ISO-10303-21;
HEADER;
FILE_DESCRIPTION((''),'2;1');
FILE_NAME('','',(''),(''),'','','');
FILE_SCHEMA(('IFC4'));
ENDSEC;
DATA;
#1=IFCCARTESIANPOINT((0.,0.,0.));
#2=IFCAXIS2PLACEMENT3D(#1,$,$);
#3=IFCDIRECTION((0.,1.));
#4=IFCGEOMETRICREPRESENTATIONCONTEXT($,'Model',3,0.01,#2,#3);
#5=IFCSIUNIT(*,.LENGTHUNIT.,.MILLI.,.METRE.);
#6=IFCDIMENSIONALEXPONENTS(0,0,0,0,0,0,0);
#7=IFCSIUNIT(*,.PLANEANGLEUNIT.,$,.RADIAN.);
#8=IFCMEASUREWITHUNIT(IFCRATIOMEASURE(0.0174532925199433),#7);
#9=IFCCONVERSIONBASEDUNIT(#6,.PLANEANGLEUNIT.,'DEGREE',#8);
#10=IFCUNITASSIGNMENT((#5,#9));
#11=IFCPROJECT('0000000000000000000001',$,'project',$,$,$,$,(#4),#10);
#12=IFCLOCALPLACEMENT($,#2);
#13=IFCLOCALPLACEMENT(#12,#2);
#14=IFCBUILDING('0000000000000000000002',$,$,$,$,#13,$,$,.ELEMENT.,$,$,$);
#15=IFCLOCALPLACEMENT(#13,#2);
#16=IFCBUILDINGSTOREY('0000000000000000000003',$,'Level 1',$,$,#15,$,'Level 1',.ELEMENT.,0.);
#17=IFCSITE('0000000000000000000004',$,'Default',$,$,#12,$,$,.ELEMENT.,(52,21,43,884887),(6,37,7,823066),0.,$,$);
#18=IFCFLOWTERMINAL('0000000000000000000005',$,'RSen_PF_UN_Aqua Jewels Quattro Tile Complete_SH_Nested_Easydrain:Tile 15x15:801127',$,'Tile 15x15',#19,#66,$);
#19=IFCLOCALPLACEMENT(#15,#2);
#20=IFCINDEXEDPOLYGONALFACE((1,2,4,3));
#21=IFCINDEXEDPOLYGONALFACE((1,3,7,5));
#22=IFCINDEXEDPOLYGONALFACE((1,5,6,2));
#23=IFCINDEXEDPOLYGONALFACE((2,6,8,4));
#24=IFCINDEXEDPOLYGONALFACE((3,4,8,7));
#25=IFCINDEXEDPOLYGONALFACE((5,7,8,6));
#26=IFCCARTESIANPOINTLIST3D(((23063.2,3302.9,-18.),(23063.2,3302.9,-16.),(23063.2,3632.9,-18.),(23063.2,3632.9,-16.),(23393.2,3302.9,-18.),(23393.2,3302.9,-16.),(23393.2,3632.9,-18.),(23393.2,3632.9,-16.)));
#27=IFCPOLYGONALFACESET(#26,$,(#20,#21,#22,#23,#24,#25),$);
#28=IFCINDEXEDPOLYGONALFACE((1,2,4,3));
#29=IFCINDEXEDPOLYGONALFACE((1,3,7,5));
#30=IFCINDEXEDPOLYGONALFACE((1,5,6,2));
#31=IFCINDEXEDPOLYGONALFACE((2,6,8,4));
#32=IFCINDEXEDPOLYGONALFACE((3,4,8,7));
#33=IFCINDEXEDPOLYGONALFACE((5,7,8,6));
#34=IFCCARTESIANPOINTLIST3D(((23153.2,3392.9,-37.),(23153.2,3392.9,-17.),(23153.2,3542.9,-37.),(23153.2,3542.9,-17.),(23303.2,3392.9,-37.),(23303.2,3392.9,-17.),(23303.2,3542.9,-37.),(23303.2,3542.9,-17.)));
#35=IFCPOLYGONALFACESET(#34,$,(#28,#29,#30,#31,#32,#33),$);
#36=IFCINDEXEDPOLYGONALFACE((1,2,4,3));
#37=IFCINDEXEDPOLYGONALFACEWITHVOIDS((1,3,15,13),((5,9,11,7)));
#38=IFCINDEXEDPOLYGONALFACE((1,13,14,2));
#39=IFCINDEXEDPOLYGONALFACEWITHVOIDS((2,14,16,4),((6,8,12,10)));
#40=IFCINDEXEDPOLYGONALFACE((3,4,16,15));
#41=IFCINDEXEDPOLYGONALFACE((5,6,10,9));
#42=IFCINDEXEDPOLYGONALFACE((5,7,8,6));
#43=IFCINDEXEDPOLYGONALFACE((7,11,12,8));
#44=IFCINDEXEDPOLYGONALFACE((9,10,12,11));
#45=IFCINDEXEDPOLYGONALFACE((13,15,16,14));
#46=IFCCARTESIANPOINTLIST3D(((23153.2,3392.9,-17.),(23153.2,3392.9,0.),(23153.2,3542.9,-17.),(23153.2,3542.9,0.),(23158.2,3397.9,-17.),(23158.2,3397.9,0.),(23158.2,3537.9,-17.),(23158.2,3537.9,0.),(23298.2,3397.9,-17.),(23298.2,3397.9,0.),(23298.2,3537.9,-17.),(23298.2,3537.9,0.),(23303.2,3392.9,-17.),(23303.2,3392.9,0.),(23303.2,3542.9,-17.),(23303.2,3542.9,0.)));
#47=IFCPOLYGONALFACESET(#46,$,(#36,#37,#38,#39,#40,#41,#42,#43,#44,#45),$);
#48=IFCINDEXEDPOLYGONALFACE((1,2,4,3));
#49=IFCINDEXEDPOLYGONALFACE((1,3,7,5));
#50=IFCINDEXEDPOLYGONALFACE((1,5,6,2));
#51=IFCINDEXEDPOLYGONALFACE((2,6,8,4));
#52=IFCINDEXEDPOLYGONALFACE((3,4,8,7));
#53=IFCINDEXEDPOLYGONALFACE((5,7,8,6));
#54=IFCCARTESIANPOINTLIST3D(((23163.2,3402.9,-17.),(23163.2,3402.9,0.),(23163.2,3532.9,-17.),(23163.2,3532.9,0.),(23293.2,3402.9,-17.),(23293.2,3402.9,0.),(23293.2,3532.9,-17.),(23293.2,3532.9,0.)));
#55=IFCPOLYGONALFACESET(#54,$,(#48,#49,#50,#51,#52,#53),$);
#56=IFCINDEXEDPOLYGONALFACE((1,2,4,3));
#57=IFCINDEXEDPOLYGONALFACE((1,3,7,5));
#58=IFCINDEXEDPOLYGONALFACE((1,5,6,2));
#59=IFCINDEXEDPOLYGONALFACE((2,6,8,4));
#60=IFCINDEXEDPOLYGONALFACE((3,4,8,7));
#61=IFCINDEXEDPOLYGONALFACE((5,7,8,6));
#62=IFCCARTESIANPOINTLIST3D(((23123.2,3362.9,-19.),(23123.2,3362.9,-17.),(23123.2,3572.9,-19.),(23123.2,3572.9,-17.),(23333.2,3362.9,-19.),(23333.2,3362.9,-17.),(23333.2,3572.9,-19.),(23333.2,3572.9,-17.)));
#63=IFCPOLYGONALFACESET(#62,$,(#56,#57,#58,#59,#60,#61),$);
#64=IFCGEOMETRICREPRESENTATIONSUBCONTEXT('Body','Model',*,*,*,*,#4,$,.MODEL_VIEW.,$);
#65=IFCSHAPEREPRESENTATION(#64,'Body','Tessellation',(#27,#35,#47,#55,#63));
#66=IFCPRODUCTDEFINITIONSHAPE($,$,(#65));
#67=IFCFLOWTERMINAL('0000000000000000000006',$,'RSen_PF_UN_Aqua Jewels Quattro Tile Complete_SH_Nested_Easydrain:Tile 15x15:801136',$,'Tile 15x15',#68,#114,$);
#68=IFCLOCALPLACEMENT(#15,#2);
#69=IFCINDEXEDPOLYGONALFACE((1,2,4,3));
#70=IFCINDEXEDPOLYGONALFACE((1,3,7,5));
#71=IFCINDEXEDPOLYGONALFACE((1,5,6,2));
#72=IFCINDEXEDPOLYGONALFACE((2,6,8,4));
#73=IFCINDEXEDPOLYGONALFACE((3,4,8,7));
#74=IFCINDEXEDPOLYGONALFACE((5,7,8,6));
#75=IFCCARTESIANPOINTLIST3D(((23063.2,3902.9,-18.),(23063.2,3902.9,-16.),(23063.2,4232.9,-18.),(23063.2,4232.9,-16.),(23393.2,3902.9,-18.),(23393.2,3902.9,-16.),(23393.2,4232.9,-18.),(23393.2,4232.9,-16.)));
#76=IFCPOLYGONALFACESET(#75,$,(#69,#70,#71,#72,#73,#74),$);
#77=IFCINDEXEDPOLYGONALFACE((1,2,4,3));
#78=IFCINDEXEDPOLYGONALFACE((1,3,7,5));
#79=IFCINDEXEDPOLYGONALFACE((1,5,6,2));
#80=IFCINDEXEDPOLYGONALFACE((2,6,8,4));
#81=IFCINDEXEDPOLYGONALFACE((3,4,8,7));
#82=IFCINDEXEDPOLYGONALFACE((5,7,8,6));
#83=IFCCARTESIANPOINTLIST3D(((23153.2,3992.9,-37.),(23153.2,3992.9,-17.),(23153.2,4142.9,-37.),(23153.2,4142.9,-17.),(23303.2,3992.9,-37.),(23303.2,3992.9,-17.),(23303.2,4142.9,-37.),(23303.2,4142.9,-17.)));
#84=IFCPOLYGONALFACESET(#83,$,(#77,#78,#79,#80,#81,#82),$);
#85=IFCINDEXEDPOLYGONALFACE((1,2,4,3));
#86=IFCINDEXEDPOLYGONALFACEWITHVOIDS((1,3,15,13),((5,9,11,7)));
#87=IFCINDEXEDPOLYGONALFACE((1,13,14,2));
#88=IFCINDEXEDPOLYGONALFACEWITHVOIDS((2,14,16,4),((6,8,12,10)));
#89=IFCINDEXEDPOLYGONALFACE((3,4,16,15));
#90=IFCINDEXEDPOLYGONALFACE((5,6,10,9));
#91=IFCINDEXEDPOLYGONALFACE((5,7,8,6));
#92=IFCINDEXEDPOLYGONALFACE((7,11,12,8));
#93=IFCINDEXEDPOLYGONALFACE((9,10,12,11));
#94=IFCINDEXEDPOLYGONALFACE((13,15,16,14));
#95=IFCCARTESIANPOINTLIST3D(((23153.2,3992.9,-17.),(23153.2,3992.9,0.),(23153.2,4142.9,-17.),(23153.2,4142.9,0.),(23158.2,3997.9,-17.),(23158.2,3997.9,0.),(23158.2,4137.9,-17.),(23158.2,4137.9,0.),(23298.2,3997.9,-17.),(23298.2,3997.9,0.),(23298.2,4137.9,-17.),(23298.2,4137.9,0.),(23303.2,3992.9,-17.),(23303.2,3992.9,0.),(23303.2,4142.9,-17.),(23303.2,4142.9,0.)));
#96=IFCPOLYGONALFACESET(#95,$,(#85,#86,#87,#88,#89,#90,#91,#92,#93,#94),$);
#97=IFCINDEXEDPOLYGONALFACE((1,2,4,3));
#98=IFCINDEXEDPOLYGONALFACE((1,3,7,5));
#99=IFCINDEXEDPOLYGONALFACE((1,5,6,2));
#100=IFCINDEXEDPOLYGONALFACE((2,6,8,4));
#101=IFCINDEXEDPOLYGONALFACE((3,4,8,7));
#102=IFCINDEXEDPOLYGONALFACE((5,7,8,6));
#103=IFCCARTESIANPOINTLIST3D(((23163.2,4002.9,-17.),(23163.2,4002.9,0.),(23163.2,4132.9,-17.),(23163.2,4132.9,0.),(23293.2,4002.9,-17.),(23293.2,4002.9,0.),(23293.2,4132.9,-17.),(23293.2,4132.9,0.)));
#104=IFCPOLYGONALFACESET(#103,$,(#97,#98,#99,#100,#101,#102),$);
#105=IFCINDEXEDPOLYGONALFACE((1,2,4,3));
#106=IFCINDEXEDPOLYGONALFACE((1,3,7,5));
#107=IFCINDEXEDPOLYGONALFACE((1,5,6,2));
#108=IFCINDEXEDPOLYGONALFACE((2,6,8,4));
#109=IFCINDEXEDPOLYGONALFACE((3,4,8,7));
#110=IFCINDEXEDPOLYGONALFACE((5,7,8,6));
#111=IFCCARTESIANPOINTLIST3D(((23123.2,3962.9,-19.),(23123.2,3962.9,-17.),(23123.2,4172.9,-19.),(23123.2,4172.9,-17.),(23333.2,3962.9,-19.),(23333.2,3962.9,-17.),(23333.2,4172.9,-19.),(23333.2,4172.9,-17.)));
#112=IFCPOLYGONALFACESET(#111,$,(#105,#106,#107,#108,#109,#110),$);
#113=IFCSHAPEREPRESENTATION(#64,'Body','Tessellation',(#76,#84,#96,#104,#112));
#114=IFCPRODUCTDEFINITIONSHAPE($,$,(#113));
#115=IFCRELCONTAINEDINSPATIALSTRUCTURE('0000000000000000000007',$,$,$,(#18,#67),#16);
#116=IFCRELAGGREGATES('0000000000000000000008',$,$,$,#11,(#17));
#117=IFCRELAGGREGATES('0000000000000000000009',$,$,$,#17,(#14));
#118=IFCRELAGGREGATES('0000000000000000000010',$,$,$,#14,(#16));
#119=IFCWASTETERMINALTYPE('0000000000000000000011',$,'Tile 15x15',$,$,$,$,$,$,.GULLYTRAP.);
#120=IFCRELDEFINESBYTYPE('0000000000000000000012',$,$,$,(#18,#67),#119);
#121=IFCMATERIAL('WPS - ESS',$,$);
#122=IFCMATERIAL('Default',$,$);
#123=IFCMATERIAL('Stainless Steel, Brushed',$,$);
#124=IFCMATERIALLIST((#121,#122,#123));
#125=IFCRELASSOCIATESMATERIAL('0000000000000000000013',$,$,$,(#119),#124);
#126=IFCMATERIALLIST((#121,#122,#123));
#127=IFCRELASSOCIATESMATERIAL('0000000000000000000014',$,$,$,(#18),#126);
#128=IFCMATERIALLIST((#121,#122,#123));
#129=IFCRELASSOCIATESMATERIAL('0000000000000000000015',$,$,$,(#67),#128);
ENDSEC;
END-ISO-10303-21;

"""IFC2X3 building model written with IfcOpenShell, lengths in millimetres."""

from ifc_helpers import new_model, entity, si_unit, converted_unit, direction, frame, origin, origin_2d_with_axis, place, context, subcontext, project, spatial, polyline, rectangle, outline, extrude, source, transform, mapped, material, material_list, type_object, type_shapes, element, save


model = new_model("IFC2X3")

# Units and contexts
model_context = context("Model", 3, precision=0.01, world=origin(), true_north=direction((0.0, 1.0)))
body_context = subcontext(model_context, "Body", "Model", "MODEL_VIEW")
ifc_project = project(units=[si_unit("LENGTHUNIT", "METRE", prefix="MILLI"), converted_unit("PLANEANGLEUNIT", "DEGREE", entity("IfcRatioMeasure", 0.0174532925199433), si_unit("PLANEANGLEUNIT", "RADIAN"), dimensions=[0, 0, 0, 0, 0, 0, 0])], contexts=[model_context])

# Site, building, storey
site_placement = place(None, origin())
site = spatial("IfcSite", under=ifc_project, at=site_placement, Name="Default", CompositionType="ELEMENT", RefLatitude=(52, 21, 43, 884887), RefLongitude=(6, 37, 7, 823066), RefElevation=0.0)
building_placement = place(site_placement, origin())
building = spatial("IfcBuilding", under=site, at=building_placement, CompositionType="ELEMENT")
storey_placement = place(building_placement, origin())
storey = spatial("IfcBuildingStorey", under=building, at=storey_placement, Name="Level 1", LongName="Level 1", CompositionType="ELEMENT", Elevation=0.0)

# Flow terminals
ifc_material_1 = material(Name="WPS - ESS")
ifc_material_2 = material(Name="Stainless Steel, Brushed")
ifc_material_3 = material(Name="Default")
ifc_material_list_1 = material_list([ifc_material_1, ifc_material_3, ifc_material_2])
ifc_material_list_2 = material_list([ifc_material_1, ifc_material_3, ifc_material_2])
waste_terminal_type_1 = type_object("IfcWasteTerminalType", Name="Tile 15x15", PredefinedType="GULLYTRAP", material=ifc_material_list_2)
shared_shape_1 = source(origin(), body_context, "Body", "SweptSolid", [
    extrude(rectangle(XDim=330.0, YDim=330.0, at=origin_2d_with_axis()), frame((5.0, -10.0, -18.0), z_axis=(0.0, 0.0, 1.0), x_axis=(-1.0, 0.0, 0.0)), (0.0, 0.0, 1.0), 2.0),
    extrude(rectangle(XDim=150.0, YDim=150.0, at=origin_2d_with_axis()), frame((5.0, -10.0, -37.0), z_axis=(0.0, 0.0, 1.0), x_axis=(-1.0, 0.0, 0.0)), (0.0, 0.0, 1.0), 20.0),
    extrude(outline(polyline([(-75.0, -75.0), (75.0, -75.0), (75.0, 75.0), (-75.0, 75.0), (-75.0, -75.0)]), holes=[polyline([(-70.0, -70.0), (-70.0, 70.0), (70.0, 70.0), (70.0, -70.0), (-70.0, -70.0)])]), frame((5.0, -10.0, -17.0), z_axis=(0.0, 0.0, 1.0), x_axis=(-1.0, 0.0, 0.0)), (0.0, 0.0, 1.0), 17.0),
    extrude(rectangle(XDim=130.0, YDim=130.0, at=origin_2d_with_axis()), frame((5.0, -10.0, -17.0), z_axis=(0.0, 0.0, 1.0), x_axis=(-1.0, 0.0, 0.0)), (0.0, 0.0, 1.0), 17.0),
    extrude(rectangle(XDim=210.0, YDim=210.0, at=origin_2d_with_axis()), frame((5.0, -10.0, -19.0), z_axis=(0.0, 0.0, 1.0), x_axis=(-1.0, 0.0, 0.0)), (0.0, 0.0, 1.0), 2.0),
])
type_shapes(waste_terminal_type_1, [shared_shape_1])
flow_terminal_1_placement = place(storey_placement, frame((23223.2, 3477.9, 0.0)))
element("IfcFlowTerminal", 1, at=flow_terminal_1_placement, inside=storey, type_object=waste_terminal_type_1, material=ifc_material_list_1, Name="RSen_PF_UN_Aqua Jewels Quattro Tile Complete_SH_Nested_Easydrain:Tile 15x15:801127", ObjectType="Tile 15x15", context=body_context, shape_type="MappedRepresentation", body=[
    mapped(shared_shape_1, transform((0.0, 0.0, 0.0), scale=1.0)),
])
ifc_material_list_3 = material_list([ifc_material_1, ifc_material_3, ifc_material_2])
flow_terminal_2_placement = place(storey_placement, frame((23223.2, 4077.9, 0.0)))
element("IfcFlowTerminal", 2, at=flow_terminal_2_placement, inside=storey, type_object=waste_terminal_type_1, material=ifc_material_list_3, Name="RSen_PF_UN_Aqua Jewels Quattro Tile Complete_SH_Nested_Easydrain:Tile 15x15:801136", ObjectType="Tile 15x15", context=body_context, shape_type="MappedRepresentation", body=[
    mapped(shared_shape_1, transform((0.0, 0.0, 0.0), scale=1.0)),
])

save(model, "model.ifc")
